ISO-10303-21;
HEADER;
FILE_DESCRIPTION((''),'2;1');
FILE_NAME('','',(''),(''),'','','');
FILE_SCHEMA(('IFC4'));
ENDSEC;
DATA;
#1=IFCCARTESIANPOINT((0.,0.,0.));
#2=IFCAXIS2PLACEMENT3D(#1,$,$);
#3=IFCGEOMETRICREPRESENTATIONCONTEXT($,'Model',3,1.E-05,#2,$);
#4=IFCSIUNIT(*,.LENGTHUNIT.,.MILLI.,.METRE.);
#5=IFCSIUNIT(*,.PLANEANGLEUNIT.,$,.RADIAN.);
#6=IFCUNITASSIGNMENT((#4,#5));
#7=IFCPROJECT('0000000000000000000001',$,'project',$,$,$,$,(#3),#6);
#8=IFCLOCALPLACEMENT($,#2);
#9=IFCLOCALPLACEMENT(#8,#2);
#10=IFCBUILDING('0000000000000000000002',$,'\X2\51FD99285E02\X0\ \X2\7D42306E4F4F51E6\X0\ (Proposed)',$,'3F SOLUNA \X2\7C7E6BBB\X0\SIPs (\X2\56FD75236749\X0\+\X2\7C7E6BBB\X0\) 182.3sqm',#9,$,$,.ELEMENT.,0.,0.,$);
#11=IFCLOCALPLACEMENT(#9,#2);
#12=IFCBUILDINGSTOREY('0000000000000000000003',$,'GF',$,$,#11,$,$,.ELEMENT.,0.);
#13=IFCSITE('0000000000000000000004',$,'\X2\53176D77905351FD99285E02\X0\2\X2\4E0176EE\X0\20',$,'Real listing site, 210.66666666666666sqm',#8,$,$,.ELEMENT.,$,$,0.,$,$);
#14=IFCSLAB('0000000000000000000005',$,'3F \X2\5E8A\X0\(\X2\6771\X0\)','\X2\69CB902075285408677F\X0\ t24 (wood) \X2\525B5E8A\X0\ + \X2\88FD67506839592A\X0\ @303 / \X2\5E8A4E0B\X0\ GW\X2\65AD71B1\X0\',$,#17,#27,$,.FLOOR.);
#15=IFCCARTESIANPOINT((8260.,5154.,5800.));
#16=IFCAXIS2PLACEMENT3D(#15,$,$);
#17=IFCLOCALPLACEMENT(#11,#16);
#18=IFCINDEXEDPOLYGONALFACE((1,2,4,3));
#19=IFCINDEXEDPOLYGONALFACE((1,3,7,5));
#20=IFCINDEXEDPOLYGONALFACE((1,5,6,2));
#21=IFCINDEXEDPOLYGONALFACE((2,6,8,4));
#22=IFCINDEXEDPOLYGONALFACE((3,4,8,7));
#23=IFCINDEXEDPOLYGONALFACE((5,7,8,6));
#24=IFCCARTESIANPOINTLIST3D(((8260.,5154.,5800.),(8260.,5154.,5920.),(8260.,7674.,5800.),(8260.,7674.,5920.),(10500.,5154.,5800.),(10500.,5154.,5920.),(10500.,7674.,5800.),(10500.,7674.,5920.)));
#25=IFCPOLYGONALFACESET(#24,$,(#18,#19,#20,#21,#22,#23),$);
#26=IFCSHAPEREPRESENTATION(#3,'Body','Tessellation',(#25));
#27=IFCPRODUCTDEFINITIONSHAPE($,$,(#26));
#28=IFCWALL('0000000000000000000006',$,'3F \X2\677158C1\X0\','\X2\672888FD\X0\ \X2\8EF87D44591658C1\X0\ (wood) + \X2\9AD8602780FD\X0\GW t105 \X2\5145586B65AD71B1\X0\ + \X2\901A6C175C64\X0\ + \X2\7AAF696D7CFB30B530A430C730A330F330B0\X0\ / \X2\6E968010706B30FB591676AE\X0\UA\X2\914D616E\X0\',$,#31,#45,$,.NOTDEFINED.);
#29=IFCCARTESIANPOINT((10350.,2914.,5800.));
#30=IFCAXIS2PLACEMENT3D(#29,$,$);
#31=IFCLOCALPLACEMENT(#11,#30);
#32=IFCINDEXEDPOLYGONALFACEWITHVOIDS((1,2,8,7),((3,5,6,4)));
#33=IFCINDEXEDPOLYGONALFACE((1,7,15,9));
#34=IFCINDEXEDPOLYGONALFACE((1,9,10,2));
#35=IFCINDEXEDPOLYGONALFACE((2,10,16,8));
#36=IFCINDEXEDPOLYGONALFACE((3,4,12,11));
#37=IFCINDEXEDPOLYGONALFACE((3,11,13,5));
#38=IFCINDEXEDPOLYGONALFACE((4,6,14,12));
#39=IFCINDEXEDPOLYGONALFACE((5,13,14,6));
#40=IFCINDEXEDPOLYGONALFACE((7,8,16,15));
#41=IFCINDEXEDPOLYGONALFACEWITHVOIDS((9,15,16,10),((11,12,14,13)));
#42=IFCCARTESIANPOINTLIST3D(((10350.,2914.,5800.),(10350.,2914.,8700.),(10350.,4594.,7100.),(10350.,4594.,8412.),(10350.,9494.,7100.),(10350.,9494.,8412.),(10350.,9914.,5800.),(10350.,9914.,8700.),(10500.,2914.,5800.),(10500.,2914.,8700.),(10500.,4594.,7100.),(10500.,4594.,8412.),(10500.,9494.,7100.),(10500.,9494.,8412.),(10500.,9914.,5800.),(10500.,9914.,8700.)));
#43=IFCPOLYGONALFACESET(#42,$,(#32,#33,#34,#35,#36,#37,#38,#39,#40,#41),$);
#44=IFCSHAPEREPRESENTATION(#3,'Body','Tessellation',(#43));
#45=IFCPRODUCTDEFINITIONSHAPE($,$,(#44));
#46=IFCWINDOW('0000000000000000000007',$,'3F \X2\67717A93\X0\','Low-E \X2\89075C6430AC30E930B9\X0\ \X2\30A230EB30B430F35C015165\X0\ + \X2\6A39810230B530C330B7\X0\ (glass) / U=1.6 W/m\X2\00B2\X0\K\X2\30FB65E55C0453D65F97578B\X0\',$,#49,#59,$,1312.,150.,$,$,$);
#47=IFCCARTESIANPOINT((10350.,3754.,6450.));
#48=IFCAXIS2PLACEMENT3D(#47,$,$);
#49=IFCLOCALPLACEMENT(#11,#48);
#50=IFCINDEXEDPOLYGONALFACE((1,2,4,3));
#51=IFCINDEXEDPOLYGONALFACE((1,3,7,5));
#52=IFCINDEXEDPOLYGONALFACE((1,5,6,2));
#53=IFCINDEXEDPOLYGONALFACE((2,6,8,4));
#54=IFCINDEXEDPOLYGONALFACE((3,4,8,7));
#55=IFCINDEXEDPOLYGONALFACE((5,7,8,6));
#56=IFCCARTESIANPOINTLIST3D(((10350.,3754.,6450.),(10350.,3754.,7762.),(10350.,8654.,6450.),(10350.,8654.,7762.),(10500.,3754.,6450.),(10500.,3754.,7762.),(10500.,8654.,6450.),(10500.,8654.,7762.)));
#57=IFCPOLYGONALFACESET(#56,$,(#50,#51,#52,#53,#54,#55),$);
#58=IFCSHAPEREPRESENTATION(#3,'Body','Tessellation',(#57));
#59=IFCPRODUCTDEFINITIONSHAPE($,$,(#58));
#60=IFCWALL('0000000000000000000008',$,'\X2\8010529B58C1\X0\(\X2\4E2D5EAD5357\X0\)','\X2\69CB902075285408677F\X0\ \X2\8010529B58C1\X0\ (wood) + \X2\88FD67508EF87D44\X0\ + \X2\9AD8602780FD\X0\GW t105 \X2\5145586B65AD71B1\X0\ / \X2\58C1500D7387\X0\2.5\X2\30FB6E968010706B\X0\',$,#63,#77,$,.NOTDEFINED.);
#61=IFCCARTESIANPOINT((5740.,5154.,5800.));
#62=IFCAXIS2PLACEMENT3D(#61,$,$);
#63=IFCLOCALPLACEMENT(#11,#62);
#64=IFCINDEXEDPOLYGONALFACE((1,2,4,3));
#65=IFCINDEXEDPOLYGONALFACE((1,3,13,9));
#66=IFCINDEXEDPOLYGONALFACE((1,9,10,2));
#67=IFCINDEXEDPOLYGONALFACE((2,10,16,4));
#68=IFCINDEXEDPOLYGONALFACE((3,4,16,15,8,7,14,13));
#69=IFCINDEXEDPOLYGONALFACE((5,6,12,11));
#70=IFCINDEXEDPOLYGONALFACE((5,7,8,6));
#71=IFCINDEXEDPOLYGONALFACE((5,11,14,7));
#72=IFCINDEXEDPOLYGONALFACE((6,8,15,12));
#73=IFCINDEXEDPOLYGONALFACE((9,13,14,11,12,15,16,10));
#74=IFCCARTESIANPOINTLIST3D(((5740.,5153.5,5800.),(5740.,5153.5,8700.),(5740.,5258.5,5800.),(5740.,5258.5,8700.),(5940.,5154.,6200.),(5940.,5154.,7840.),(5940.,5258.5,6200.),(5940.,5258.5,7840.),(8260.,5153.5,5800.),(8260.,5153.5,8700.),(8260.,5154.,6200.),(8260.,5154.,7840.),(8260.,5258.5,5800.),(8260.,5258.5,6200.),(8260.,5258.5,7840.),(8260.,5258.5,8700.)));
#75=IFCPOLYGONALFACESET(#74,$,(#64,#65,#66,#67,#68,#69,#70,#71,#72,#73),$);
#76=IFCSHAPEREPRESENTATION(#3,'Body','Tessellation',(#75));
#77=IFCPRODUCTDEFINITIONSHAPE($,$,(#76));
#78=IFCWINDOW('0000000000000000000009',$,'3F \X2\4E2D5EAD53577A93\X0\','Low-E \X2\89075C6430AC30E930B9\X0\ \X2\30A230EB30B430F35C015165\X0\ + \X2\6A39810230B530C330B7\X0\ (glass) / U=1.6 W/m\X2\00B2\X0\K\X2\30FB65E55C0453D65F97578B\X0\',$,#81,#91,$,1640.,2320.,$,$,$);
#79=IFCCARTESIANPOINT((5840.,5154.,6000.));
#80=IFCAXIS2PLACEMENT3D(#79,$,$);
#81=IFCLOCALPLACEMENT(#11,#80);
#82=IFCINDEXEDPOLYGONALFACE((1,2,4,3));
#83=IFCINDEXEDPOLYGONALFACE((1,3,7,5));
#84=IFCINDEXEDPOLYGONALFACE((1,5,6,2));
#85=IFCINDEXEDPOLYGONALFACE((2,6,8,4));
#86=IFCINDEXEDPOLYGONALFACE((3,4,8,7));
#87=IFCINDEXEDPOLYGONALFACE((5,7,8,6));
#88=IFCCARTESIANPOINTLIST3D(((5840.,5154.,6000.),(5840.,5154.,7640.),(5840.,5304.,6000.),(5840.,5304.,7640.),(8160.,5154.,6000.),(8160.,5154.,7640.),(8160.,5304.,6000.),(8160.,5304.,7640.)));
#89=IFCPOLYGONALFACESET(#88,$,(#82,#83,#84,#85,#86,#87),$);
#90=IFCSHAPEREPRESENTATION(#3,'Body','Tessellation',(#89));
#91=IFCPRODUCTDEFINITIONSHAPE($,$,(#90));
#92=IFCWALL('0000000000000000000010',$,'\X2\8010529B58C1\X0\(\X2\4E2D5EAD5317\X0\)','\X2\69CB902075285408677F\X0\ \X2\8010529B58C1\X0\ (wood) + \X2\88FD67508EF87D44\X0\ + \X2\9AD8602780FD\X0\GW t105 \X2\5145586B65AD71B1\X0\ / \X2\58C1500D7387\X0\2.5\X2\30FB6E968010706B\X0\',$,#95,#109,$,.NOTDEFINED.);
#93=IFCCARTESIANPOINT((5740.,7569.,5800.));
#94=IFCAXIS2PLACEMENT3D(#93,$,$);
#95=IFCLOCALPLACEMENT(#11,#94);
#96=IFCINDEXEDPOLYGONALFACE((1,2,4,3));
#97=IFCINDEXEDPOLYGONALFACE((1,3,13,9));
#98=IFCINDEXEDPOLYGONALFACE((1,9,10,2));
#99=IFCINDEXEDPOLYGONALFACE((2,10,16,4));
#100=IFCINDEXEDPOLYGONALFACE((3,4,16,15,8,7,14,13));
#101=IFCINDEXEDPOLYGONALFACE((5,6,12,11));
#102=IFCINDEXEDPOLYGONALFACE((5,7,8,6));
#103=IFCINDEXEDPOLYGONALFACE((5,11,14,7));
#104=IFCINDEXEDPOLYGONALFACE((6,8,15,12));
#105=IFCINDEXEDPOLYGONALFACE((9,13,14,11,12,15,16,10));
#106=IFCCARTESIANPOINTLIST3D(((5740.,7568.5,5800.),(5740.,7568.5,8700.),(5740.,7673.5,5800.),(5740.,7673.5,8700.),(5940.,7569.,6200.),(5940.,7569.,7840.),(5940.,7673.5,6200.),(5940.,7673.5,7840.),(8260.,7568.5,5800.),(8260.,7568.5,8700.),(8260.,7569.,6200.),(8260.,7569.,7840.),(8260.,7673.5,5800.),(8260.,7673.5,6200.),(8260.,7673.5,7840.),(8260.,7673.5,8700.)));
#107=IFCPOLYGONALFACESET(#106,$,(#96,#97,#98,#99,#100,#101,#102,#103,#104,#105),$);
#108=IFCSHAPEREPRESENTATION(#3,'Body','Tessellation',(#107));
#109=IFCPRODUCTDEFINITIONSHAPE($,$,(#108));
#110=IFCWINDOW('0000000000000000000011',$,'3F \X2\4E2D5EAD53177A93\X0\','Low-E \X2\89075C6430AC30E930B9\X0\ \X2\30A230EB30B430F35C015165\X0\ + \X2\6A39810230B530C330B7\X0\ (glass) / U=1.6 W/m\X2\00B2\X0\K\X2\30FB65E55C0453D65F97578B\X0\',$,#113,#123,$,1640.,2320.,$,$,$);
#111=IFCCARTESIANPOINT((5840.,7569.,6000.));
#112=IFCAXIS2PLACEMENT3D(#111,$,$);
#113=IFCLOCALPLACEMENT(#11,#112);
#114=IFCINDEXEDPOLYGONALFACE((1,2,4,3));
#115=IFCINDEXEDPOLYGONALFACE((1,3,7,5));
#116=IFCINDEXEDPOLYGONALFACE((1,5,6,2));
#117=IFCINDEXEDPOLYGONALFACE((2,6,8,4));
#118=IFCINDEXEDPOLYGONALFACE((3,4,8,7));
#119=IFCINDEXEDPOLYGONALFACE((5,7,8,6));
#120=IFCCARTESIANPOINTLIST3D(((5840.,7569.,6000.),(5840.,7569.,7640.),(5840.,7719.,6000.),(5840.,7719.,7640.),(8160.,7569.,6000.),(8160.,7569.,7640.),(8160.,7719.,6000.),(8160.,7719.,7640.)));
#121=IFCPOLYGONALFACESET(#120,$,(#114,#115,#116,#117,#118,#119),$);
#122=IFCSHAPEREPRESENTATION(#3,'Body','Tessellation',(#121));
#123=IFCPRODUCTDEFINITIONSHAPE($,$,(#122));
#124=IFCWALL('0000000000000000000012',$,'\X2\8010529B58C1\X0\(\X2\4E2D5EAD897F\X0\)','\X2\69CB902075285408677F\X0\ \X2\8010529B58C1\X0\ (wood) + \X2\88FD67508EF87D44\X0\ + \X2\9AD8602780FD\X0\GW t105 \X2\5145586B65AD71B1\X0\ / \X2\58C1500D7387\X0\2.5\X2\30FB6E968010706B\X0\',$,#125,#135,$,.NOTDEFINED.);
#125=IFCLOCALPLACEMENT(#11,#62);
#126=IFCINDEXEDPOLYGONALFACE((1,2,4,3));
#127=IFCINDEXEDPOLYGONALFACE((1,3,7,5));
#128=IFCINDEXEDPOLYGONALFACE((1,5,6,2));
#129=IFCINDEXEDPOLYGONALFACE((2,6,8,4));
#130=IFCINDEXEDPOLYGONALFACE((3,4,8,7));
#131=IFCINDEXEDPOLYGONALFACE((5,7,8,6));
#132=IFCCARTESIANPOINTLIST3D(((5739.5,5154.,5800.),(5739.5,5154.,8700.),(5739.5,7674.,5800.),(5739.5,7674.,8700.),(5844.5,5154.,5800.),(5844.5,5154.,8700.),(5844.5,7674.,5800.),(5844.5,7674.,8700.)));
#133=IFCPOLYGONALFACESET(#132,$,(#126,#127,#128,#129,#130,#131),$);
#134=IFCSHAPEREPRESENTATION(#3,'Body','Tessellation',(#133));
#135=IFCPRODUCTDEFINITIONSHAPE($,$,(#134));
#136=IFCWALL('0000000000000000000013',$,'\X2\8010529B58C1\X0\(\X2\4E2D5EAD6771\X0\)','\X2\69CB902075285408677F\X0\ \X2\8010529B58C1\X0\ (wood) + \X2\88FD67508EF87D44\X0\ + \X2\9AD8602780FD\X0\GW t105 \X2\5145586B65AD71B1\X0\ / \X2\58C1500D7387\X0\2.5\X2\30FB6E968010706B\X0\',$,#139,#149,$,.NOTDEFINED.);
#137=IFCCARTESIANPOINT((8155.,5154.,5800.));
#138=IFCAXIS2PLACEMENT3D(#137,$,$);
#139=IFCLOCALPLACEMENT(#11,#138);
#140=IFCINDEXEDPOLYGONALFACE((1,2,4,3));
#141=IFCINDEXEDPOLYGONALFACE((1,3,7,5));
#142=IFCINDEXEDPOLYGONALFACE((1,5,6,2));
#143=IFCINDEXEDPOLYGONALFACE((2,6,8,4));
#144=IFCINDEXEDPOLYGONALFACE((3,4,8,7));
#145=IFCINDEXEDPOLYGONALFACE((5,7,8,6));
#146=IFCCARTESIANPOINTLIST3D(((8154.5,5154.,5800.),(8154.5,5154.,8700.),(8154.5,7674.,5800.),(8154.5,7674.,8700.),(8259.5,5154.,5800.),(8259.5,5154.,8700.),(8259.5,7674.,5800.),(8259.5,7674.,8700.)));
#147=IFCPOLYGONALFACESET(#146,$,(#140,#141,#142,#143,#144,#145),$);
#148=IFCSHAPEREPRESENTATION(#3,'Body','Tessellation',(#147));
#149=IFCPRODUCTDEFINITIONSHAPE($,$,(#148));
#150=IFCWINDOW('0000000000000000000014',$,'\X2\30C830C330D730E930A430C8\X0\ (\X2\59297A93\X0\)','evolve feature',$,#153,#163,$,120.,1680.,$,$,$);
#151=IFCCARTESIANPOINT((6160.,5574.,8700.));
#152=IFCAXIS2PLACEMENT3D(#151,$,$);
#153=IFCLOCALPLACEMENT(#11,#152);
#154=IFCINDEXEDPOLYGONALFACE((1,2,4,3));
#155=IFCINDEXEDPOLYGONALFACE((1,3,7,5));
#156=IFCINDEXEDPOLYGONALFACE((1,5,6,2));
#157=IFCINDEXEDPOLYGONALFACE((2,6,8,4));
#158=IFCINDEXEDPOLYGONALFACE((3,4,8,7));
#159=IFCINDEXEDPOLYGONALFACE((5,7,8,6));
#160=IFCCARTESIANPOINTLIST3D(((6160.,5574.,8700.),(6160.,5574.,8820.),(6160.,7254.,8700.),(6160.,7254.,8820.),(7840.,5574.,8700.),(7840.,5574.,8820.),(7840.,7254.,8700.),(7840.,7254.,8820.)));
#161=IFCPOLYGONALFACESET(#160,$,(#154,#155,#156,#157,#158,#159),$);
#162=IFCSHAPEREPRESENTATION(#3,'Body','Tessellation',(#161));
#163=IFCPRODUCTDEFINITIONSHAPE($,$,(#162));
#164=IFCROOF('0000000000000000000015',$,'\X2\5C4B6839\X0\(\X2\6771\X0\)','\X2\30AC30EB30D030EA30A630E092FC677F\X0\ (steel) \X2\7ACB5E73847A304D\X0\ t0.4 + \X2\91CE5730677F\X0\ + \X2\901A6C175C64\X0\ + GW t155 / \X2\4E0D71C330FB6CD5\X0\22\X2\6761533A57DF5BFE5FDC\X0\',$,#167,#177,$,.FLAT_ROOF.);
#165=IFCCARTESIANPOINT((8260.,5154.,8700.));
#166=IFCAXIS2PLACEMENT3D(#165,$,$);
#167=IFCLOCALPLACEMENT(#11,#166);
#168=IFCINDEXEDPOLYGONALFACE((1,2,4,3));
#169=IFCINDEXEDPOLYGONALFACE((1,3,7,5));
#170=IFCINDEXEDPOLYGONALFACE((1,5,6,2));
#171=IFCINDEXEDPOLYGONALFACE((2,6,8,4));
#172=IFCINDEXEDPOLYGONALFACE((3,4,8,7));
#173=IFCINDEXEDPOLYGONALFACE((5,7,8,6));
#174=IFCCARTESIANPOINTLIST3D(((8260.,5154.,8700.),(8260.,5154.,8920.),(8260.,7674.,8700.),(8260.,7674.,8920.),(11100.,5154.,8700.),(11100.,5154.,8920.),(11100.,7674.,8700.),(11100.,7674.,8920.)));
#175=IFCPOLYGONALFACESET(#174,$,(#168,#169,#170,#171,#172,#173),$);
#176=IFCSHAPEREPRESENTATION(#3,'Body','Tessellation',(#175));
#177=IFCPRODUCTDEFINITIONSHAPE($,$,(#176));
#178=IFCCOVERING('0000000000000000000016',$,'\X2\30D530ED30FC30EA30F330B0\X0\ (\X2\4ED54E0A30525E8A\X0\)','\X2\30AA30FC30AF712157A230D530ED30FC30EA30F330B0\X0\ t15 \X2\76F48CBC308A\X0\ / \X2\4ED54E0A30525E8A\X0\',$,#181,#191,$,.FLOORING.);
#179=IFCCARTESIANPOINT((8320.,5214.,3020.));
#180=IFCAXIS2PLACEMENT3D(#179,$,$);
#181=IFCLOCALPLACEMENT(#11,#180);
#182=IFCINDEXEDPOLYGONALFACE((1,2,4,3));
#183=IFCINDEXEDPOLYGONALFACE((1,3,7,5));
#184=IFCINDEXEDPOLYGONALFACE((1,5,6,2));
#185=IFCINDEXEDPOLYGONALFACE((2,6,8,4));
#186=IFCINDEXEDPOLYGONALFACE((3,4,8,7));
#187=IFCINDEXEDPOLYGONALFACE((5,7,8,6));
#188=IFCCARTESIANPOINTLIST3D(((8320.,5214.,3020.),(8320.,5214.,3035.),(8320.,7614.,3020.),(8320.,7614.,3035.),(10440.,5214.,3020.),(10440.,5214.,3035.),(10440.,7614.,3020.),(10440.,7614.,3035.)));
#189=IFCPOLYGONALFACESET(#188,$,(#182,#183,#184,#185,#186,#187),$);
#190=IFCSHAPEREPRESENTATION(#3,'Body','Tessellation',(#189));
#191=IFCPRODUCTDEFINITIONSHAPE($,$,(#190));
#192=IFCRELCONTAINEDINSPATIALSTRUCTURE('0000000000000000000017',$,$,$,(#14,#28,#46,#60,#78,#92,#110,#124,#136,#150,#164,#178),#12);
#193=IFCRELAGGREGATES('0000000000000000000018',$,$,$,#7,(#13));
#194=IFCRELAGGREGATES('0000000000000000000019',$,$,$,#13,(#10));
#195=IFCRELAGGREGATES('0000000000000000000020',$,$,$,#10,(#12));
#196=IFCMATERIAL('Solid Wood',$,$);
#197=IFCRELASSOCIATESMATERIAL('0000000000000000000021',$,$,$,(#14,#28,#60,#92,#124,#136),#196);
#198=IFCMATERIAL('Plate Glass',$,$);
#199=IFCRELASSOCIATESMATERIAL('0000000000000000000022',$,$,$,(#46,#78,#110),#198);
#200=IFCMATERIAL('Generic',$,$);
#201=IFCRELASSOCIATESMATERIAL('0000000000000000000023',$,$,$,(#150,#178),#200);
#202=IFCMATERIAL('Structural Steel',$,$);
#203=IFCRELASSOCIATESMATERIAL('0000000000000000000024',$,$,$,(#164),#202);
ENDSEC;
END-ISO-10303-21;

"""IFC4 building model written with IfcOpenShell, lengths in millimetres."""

from ifc_helpers import new_model, si_unit, frame, frame_2d, origin, place, context, project, spatial, rectangle, extrude, material, element, fill, save


model = new_model("IFC4")

# Units and contexts
model_context = context("Model", 3, precision=1e-05, world=origin())
ifc_project = project(units=[si_unit("LENGTHUNIT", "METRE", prefix="MILLI"), si_unit("PLANEANGLEUNIT", "RADIAN")], contexts=[model_context])

# Site, building, storey
site_placement = place(None, origin())
site = spatial("IfcSite", under=ifc_project, at=site_placement, Name="北海道函館市2丁目20", ObjectType="Real listing site, 210.66666666666666sqm", CompositionType="ELEMENT", RefElevation=0.0)
building_placement = place(site_placement, origin())
building = spatial("IfcBuilding", under=site, at=building_placement, Name="函館市 終の住処 (Proposed)", ObjectType="3F SOLUNA 籾殻SIPs (国産杉+籾殻) 182.3sqm", CompositionType="ELEMENT", ElevationOfRefHeight=0.0, ElevationOfTerrain=0.0)
storey_placement = place(building_placement, origin())
storey = spatial("IfcBuildingStorey", under=building, at=storey_placement, Name="GF", CompositionType="ELEMENT", Elevation=0.0)

# Slab
ifc_material_1 = material(Name="Solid Wood")
slab_placement = place(storey_placement, frame((8260.0, 5154.0, 5800.0)))
element("IfcSlab", 1, at=slab_placement, inside=storey, material=ifc_material_1, Name="3F 床(東)", Description="構造用合板 t24 (wood) 剛床 + 製材根太 @303 / 床下 GW断熱", PredefinedType="FLOOR", context=model_context, shape_type="SweptSolid", body=[
    extrude(rectangle(XDim=2240.0, YDim=2520.0, at=frame_2d((1120.0, 1260.0))), frame((8260.0, 5154.0, 5800.0)), (0.0, 0.0, 1.0), 120.0),
])

# Walls, openings, windows
wall_1_placement = place(storey_placement, frame((10350.0, 2914.0, 5800.0)))
wall_1 = element("IfcWall", 2, at=wall_1_placement, inside=storey, material=ifc_material_1, Name="3F 東壁", Description="木製 軸組外壁 (wood) + 高性能GW t105 充填断熱 + 通気層 + 窯業系サイディング / 準耐火・外皮UA配慮", PredefinedType="NOTDEFINED", context=model_context, shape_type="SweptSolid", body=[
    extrude(rectangle(XDim=150.0, YDim=7000.0, at=frame_2d((75.0, 3500.0))), frame((10350.0, 2914.0, 5800.0)), (0.0, 0.0, 1.0), 2900.0),
])
opening_1_placement = place(storey_placement, frame((10350.0, 3754.0, 6450.0)))
opening_1 = element("IfcOpeningElement", 3, at=opening_1_placement, cuts=wall_1, PredefinedType="NOTDEFINED", context=model_context, shape_type="SweptSolid", body=[
    extrude(rectangle(XDim=150.0, YDim=4900.0, at=frame_2d((75.0, 2450.0))), frame((10350.0, 3754.0, 6450.0)), (0.0, 0.0, 1.0), 1312.0),
])
ifc_material_2 = material(Name="Plate Glass")
window_1_placement = place(storey_placement, frame((10350.0, 3754.0, 6450.0)))
window_1 = element("IfcWindow", 4, at=window_1_placement, inside=storey, material=ifc_material_2, Name="3F 東窓", Description="Low-E 複層ガラス アルゴン封入 + 樹脂サッシ (glass) / U=1.6 W/m²K・日射取得型", OverallHeight=1312.0, OverallWidth=150.0, context=model_context, shape_type="SweptSolid", body=[
    extrude(rectangle(XDim=150.0, YDim=4900.0, at=frame_2d((75.0, 2450.0))), frame((10350.0, 3754.0, 6450.0)), (0.0, 0.0, 1.0), 1312.0),
])
fill(opening_1, window_1)
wall_2_placement = place(storey_placement, frame((5740.0, 5154.0, 5800.0)))
wall_2 = element("IfcWall", 5, at=wall_2_placement, inside=storey, material=ifc_material_1, Name="耐力壁(中庭南)", Description="構造用合板 耐力壁 (wood) + 製材軸組 + 高性能GW t105 充填断熱 / 壁倍率2.5・準耐火", PredefinedType="NOTDEFINED", context=model_context, shape_type="SweptSolid", body=[
    extrude(rectangle(XDim=2520.0, YDim=105.0, at=frame_2d((1260.0, 52.0))), frame((5740.0, 5154.0, 5800.0)), (0.0, 0.0, 1.0), 2900.0),
])
opening_2_placement = place(storey_placement, frame((5840.0, 5154.0, 6000.0)))
opening_2 = element("IfcOpeningElement", 6, at=opening_2_placement, cuts=wall_2, PredefinedType="NOTDEFINED", context=model_context, shape_type="SweptSolid", body=[
    extrude(rectangle(XDim=2320.0, YDim=150.0, at=frame_2d((1160.0, 75.0))), frame((5840.0, 5154.0, 6000.0)), (0.0, 0.0, 1.0), 1640.0),
])
window_2_placement = place(storey_placement, frame((5840.0, 5154.0, 6000.0)))
window_2 = element("IfcWindow", 7, at=window_2_placement, inside=storey, material=ifc_material_2, Name="3F 中庭南窓", Description="Low-E 複層ガラス アルゴン封入 + 樹脂サッシ (glass) / U=1.6 W/m²K・日射取得型", OverallHeight=1640.0, OverallWidth=2320.0, context=model_context, shape_type="SweptSolid", body=[
    extrude(rectangle(XDim=2320.0, YDim=150.0, at=frame_2d((1160.0, 75.0))), frame((5840.0, 5154.0, 6000.0)), (0.0, 0.0, 1.0), 1640.0),
])
fill(opening_2, window_2)
wall_3_placement = place(storey_placement, frame((5740.0, 7569.0, 5800.0)))
wall_3 = element("IfcWall", 8, at=wall_3_placement, inside=storey, material=ifc_material_1, Name="耐力壁(中庭北)", Description="構造用合板 耐力壁 (wood) + 製材軸組 + 高性能GW t105 充填断熱 / 壁倍率2.5・準耐火", PredefinedType="NOTDEFINED", context=model_context, shape_type="SweptSolid", body=[
    extrude(rectangle(XDim=2520.0, YDim=105.0, at=frame_2d((1260.0, 52.0))), frame((5740.0, 7569.0, 5800.0)), (0.0, 0.0, 1.0), 2900.0),
])
opening_3_placement = place(storey_placement, frame((5840.0, 7569.0, 6000.0)))
opening_3 = element("IfcOpeningElement", 9, at=opening_3_placement, cuts=wall_3, PredefinedType="NOTDEFINED", context=model_context, shape_type="SweptSolid", body=[
    extrude(rectangle(XDim=2320.0, YDim=150.0, at=frame_2d((1160.0, 75.0))), frame((5840.0, 7569.0, 6000.0)), (0.0, 0.0, 1.0), 1640.0),
])
window_3_placement = place(storey_placement, frame((5840.0, 7569.0, 6000.0)))
window_3 = element("IfcWindow", 10, at=window_3_placement, inside=storey, material=ifc_material_2, Name="3F 中庭北窓", Description="Low-E 複層ガラス アルゴン封入 + 樹脂サッシ (glass) / U=1.6 W/m²K・日射取得型", OverallHeight=1640.0, OverallWidth=2320.0, context=model_context, shape_type="SweptSolid", body=[
    extrude(rectangle(XDim=2320.0, YDim=150.0, at=frame_2d((1160.0, 75.0))), frame((5840.0, 7569.0, 6000.0)), (0.0, 0.0, 1.0), 1640.0),
])
fill(opening_3, window_3)

# Walls
wall_4_placement = place(storey_placement, frame((5740.0, 5154.0, 5800.0)))
element("IfcWall", 11, at=wall_4_placement, inside=storey, material=ifc_material_1, Name="耐力壁(中庭西)", Description="構造用合板 耐力壁 (wood) + 製材軸組 + 高性能GW t105 充填断熱 / 壁倍率2.5・準耐火", PredefinedType="NOTDEFINED", context=model_context, shape_type="SweptSolid", body=[
    extrude(rectangle(XDim=105.0, YDim=2520.0, at=frame_2d((52.0, 1260.0))), frame((5740.0, 5154.0, 5800.0)), (0.0, 0.0, 1.0), 2900.0),
])
wall_5_placement = place(storey_placement, frame((8155.0, 5154.0, 5800.0)))
element("IfcWall", 12, at=wall_5_placement, inside=storey, material=ifc_material_1, Name="耐力壁(中庭東)", Description="構造用合板 耐力壁 (wood) + 製材軸組 + 高性能GW t105 充填断熱 / 壁倍率2.5・準耐火", PredefinedType="NOTDEFINED", context=model_context, shape_type="SweptSolid", body=[
    extrude(rectangle(XDim=105.0, YDim=2520.0, at=frame_2d((52.0, 1260.0))), frame((8155.0, 5154.0, 5800.0)), (0.0, 0.0, 1.0), 2900.0),
])

# Window
ifc_material_3 = material(Name="Generic")
window_4_placement = place(storey_placement, frame((6160.0, 5574.0, 8700.0)))
element("IfcWindow", 13, at=window_4_placement, inside=storey, material=ifc_material_3, Name="トップライト (天窓)", Description="evolve feature", OverallHeight=120.0, OverallWidth=1680.0, context=model_context, shape_type="SweptSolid", body=[
    extrude(rectangle(XDim=1680.0, YDim=1680.0, at=frame_2d((840.0, 840.0))), frame((6160.0, 5574.0, 8700.0)), (0.0, 0.0, 1.0), 120.0),
])

# Roof
ifc_material_4 = material(Name="Structural Steel")
for number, where, name in (
    (14, (8260.0, 5154.0, 8700.0), "屋根(東)"),
):
    element("IfcRoof", number, at=place(storey_placement, frame(where)), inside=storey, material=ifc_material_4, Name=name, Description="ガルバリウム鋼板 (steel) 立平葺き t0.4 + 野地板 + 通気層 + GW t155 / 不燃・法22条区域対応", PredefinedType="FLAT_ROOF", context=model_context, shape_type="SweptSolid", body=[
        extrude(rectangle(XDim=2840.0, YDim=2520.0, at=frame_2d((1420.0, 1260.0))), frame((8260.0, 5154.0, 8700.0)), (0.0, 0.0, 1.0), 220.0),
    ])

# Covering
covering_1_placement = place(storey_placement, frame((8320.0, 5214.0, 3020.0)))
element("IfcCovering", 15, at=covering_1_placement, inside=storey, material=ifc_material_3, Name="フローリング (仕上げ床)", Description="オーク無垢フローリング t15 直貼り / 仕上げ床", PredefinedType="FLOORING", context=model_context, shape_type="SweptSolid", body=[
    extrude(rectangle(XDim=2120.0, YDim=2400.0, at=frame_2d((1060.0, 1200.0))), frame((8320.0, 5214.0, 3020.0)), (0.0, 0.0, 1.0), 15.0),
])

save(model, "model.ifc")
